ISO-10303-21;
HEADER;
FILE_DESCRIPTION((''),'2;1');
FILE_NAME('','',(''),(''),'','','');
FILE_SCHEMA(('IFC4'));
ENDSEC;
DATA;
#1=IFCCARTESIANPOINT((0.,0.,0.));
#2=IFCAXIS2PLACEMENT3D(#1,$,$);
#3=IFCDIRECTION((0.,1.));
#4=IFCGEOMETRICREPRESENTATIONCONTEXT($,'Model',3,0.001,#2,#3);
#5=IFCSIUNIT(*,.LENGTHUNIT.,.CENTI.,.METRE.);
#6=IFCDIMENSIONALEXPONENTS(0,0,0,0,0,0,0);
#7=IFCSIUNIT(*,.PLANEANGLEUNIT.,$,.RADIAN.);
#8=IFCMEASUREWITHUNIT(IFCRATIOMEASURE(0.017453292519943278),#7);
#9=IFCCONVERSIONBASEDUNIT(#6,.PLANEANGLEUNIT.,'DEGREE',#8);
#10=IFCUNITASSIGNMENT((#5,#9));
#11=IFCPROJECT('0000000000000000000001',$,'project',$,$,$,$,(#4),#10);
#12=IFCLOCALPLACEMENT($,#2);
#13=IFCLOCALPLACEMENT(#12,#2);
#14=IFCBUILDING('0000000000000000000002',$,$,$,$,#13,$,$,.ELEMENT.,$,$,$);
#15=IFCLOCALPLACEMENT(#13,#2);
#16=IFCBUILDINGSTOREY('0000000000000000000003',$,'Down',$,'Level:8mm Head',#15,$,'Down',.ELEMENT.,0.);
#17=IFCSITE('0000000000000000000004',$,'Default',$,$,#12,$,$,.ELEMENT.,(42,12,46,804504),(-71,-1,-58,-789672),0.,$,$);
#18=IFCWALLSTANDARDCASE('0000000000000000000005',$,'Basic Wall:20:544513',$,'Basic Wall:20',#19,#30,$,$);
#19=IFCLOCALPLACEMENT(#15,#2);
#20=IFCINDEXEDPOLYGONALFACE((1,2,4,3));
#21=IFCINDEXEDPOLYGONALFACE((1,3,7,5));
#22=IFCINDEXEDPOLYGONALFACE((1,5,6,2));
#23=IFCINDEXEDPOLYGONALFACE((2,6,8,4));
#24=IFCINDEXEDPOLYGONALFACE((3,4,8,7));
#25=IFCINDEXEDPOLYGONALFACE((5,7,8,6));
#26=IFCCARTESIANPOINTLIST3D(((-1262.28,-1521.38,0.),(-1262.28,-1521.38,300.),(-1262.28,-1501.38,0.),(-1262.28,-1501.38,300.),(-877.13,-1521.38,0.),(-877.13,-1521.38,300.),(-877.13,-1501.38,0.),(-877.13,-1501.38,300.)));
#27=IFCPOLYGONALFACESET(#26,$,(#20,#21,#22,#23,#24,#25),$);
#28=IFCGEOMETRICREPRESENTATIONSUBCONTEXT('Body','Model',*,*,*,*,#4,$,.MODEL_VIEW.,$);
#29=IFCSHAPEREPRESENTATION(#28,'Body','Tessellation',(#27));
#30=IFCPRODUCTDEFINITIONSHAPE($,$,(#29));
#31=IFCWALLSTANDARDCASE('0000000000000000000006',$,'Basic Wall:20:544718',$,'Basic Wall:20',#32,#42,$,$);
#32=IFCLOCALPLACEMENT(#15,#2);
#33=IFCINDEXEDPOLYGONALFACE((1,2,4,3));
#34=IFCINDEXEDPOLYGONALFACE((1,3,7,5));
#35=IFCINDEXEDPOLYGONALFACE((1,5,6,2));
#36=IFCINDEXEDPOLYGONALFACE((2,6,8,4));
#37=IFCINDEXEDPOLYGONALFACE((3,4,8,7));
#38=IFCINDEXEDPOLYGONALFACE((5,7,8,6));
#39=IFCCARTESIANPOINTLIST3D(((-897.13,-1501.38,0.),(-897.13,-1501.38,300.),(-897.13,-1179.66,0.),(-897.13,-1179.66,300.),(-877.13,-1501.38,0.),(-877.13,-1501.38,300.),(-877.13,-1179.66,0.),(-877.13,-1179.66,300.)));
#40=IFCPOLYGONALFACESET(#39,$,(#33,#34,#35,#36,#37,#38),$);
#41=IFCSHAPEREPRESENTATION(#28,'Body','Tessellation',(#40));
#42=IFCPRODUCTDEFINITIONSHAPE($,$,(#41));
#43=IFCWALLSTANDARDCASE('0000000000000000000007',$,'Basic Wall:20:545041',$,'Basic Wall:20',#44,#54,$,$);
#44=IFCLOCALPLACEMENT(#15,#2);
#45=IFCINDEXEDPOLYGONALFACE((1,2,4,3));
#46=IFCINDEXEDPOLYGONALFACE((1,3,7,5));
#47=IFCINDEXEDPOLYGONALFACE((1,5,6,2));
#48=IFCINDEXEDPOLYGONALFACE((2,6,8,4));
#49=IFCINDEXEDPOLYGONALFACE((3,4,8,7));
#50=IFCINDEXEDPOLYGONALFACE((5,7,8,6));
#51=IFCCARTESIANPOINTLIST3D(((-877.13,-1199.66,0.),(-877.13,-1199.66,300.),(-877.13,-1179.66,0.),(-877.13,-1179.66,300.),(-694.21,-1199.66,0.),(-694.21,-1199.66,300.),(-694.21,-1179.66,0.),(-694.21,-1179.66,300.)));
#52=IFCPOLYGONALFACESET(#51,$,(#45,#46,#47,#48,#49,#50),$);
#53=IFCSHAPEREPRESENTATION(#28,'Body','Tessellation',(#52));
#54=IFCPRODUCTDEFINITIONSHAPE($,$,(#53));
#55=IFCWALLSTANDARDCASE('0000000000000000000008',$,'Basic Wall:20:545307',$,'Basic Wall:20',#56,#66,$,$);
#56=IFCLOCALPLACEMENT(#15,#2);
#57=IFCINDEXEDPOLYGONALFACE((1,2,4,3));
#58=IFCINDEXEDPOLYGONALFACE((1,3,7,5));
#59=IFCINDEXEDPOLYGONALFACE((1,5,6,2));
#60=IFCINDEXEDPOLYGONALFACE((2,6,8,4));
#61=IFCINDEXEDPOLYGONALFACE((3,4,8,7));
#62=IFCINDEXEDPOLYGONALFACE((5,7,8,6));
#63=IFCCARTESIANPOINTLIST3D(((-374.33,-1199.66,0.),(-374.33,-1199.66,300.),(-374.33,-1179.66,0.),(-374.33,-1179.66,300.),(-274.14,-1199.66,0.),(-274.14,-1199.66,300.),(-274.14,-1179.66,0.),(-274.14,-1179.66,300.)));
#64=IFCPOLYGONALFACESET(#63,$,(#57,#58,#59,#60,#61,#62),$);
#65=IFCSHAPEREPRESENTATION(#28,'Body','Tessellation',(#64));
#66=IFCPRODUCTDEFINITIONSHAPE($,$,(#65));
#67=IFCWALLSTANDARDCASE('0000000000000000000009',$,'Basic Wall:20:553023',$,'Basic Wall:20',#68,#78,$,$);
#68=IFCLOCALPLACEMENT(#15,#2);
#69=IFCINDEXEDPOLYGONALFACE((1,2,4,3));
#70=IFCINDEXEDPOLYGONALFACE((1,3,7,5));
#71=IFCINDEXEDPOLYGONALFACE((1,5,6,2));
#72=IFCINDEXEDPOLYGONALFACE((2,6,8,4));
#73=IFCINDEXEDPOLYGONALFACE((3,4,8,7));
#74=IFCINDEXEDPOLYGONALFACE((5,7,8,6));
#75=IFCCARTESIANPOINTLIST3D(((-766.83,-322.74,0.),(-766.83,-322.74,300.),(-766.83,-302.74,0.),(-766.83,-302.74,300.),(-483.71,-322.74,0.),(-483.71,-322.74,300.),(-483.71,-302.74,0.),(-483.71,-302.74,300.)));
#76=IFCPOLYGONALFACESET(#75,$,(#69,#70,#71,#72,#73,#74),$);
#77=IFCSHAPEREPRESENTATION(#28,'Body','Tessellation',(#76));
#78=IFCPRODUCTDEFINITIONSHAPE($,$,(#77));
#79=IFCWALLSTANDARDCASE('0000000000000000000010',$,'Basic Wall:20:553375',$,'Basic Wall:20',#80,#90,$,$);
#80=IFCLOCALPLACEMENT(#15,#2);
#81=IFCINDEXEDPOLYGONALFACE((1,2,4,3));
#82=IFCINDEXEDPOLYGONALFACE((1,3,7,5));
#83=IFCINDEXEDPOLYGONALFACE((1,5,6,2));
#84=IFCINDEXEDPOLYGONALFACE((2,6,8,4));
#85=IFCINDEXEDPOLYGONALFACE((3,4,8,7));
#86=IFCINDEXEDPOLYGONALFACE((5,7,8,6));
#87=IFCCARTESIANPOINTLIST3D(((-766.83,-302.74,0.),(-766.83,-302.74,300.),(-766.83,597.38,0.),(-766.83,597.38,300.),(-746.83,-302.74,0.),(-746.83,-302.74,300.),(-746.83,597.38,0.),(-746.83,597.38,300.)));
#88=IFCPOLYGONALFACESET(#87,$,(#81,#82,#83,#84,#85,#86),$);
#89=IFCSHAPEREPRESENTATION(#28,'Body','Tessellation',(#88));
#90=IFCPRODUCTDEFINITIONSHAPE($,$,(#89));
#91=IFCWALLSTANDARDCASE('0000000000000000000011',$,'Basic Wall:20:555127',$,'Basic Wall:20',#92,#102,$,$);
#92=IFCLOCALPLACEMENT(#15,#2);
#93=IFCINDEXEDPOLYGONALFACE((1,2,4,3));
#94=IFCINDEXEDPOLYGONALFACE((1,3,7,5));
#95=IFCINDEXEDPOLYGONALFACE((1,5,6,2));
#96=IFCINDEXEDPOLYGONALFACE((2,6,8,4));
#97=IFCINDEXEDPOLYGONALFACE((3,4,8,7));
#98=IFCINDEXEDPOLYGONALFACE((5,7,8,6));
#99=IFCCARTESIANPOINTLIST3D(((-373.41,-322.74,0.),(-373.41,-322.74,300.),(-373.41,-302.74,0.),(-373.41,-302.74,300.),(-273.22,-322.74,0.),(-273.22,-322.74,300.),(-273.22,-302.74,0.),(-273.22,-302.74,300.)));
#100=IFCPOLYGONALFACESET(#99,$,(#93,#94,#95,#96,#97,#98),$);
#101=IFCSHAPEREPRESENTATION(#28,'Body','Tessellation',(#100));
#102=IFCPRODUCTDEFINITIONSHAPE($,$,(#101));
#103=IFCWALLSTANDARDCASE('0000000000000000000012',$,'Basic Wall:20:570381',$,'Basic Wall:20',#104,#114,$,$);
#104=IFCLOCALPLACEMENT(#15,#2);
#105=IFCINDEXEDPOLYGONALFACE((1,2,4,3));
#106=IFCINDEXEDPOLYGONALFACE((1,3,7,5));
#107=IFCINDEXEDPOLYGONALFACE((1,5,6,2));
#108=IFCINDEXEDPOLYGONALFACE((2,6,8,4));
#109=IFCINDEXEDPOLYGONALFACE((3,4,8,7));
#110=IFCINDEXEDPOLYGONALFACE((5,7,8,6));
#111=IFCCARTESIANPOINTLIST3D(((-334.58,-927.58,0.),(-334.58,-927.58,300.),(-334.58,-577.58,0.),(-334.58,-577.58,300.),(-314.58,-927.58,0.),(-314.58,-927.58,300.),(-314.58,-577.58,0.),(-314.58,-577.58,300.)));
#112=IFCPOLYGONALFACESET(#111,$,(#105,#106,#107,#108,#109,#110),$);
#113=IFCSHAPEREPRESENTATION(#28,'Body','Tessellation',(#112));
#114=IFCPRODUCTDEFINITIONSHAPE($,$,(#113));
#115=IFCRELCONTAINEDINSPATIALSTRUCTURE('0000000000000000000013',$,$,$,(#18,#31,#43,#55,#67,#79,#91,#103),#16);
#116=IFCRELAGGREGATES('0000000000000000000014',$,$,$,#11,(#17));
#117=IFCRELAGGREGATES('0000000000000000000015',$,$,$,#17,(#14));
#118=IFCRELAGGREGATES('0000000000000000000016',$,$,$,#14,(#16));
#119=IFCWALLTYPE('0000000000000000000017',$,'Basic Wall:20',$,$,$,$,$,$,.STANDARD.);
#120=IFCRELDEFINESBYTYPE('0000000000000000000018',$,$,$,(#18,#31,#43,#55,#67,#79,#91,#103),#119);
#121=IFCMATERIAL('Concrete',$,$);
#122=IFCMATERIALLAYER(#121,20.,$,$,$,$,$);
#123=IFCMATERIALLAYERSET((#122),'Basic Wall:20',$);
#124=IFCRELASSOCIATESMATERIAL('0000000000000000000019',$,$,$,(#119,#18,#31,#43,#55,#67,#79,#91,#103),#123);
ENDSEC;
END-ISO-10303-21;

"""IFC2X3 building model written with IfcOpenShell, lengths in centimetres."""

from ifc_helpers import new_model, entity, si_unit, converted_unit, direction, frame, frame_2d, origin, place, context, subcontext, project, spatial, rectangle, extrude, material, layer, layer_set, layer_usage, type_object, element, save


model = new_model("IFC2X3")

# Units and contexts
model_context = context("Model", 3, precision=0.001, world=origin(), true_north=direction((0.0, 1.0)))
body_context = subcontext(model_context, "Body", "Model", "MODEL_VIEW")
ifc_project = project(units=[si_unit("LENGTHUNIT", "METRE", prefix="CENTI"), converted_unit("PLANEANGLEUNIT", "DEGREE", entity("IfcRatioMeasure", 0.017453292519943278), si_unit("PLANEANGLEUNIT", "RADIAN"), dimensions=[0, 0, 0, 0, 0, 0, 0])], contexts=[model_context])

# Site, building, storey
site_placement = place(None, origin())
site = spatial("IfcSite", under=ifc_project, at=site_placement, Name="Default", CompositionType="ELEMENT", RefLatitude=(42, 12, 46, 804504), RefLongitude=(-71, -1, -58, -789672), RefElevation=0.0)
building_placement = place(site_placement, origin())
building = spatial("IfcBuilding", under=site, at=building_placement, CompositionType="ELEMENT")
storey_placement = place(building_placement, origin())
storey = spatial("IfcBuildingStorey", under=building, at=storey_placement, Name="Down", ObjectType="Level:8mm Head", LongName="Down", CompositionType="ELEMENT", Elevation=0.0)

# Walls
ifc_material = material(Name="Concrete")
ifc_layer_1 = layer(ifc_material, 20.0)
ifc_layer_set_1 = layer_set([ifc_layer_1], Name="Basic Wall:20")
wall_type_1 = type_object("IfcWallType", Name="Basic Wall:20", PredefinedType="STANDARD", material=ifc_layer_set_1)
ifc_layer_usage_1 = layer_usage(ifc_layer_set_1, "AXIS2", "POSITIVE", -10.0)
wall_1_placement = place(storey_placement, frame((-1262.28, -1511.38, 0.0)))
element("IfcWallStandardCase", 1, at=wall_1_placement, inside=storey, type_object=wall_type_1, material=ifc_layer_usage_1, Name="Basic Wall:20:544513", ObjectType="Basic Wall:20", context=body_context, shape_type="SweptSolid", body=[
    extrude(rectangle(XDim=385.15, YDim=20.0, at=frame_2d((192.57, 0.0), x_axis=(-1.0, 0.0))), origin(), (0.0, 0.0, 1.0), 300.0),
])
ifc_layer_usage_2 = layer_usage(ifc_layer_set_1, "AXIS2", "POSITIVE", -10.0)
wall_2_placement = place(storey_placement, frame((-887.13, -1501.38, 0.0), z_axis=(0.0, 0.0, 1.0), x_axis=(0.0, 1.0, 0.0)))
element("IfcWallStandardCase", 2, at=wall_2_placement, inside=storey, type_object=wall_type_1, material=ifc_layer_usage_2, Name="Basic Wall:20:544718", ObjectType="Basic Wall:20", context=body_context, shape_type="SweptSolid", body=[
    extrude(rectangle(XDim=321.72, YDim=20.0, at=frame_2d((160.86, 0.0), x_axis=(-1.0, 0.0))), origin(), (0.0, 0.0, 1.0), 300.0),
])
ifc_layer_usage_3 = layer_usage(ifc_layer_set_1, "AXIS2", "NEGATIVE", 10.0)
wall_3_placement = place(storey_placement, frame((-877.13, -1189.66, 0.0)))
element("IfcWallStandardCase", 3, at=wall_3_placement, inside=storey, type_object=wall_type_1, material=ifc_layer_usage_3, Name="Basic Wall:20:545041", ObjectType="Basic Wall:20", context=body_context, shape_type="SweptSolid", body=[
    extrude(rectangle(XDim=182.92, YDim=20.0, at=frame_2d((91.46, 0.0), x_axis=(-1.0, 0.0))), origin(), (0.0, 0.0, 1.0), 300.0),
])
ifc_layer_usage_4 = layer_usage(ifc_layer_set_1, "AXIS2", "POSITIVE", -10.0)
wall_4_placement = place(storey_placement, frame((-374.33, -1189.66, 0.0)))
element("IfcWallStandardCase", 4, at=wall_4_placement, inside=storey, type_object=wall_type_1, material=ifc_layer_usage_4, Name="Basic Wall:20:545307", ObjectType="Basic Wall:20", context=body_context, shape_type="SweptSolid", body=[
    extrude(rectangle(XDim=100.19, YDim=20.0, at=frame_2d((50.1, 0.0), x_axis=(-1.0, 0.0))), origin(), (0.0, 0.0, 1.0), 300.0),
])
ifc_layer_usage_5 = layer_usage(ifc_layer_set_1, "AXIS2", "POSITIVE", -10.0)
wall_5_placement = place(storey_placement, frame((-766.83, -312.74, 0.0)))
element("IfcWallStandardCase", 5, at=wall_5_placement, inside=storey, type_object=wall_type_1, material=ifc_layer_usage_5, Name="Basic Wall:20:553023", ObjectType="Basic Wall:20", context=body_context, shape_type="SweptSolid", body=[
    extrude(rectangle(XDim=283.11, YDim=20.0, at=frame_2d((141.56, 0.0), x_axis=(-1.0, 0.0))), origin(), (0.0, 0.0, 1.0), 300.0),
])
ifc_layer_usage_6 = layer_usage(ifc_layer_set_1, "AXIS2", "NEGATIVE", 10.0)
wall_6_placement = place(storey_placement, frame((-756.83, -302.74, 0.0), z_axis=(0.0, 0.0, 1.0), x_axis=(0.0, 1.0, 0.0)))
element("IfcWallStandardCase", 6, at=wall_6_placement, inside=storey, type_object=wall_type_1, material=ifc_layer_usage_6, Name="Basic Wall:20:553375", ObjectType="Basic Wall:20", context=body_context, shape_type="SweptSolid", body=[
    extrude(rectangle(XDim=900.12, YDim=20.0, at=frame_2d((450.06, 0.0), x_axis=(-1.0, 0.0))), origin(), (0.0, 0.0, 1.0), 300.0),
])
ifc_layer_usage_7 = layer_usage(ifc_layer_set_1, "AXIS2", "NEGATIVE", 10.0)
wall_7_placement = place(storey_placement, frame((-273.22, -312.74, 0.0), z_axis=(0.0, 0.0, 1.0), x_axis=(-1.0, 0.0, 0.0)))
element("IfcWallStandardCase", 7, at=wall_7_placement, inside=storey, type_object=wall_type_1, material=ifc_layer_usage_7, Name="Basic Wall:20:555127", ObjectType="Basic Wall:20", context=body_context, shape_type="SweptSolid", body=[
    extrude(rectangle(XDim=100.19, YDim=20.0, at=frame_2d((50.1, 0.0), x_axis=(-1.0, 0.0))), origin(), (0.0, 0.0, 1.0), 300.0),
])
ifc_layer_usage_8 = layer_usage(ifc_layer_set_1, "AXIS2", "POSITIVE", -10.0)
wall_8_placement = place(storey_placement, frame((-324.58, -927.58, 0.0), z_axis=(0.0, 0.0, 1.0), x_axis=(0.0, 1.0, 0.0)))
element("IfcWallStandardCase", 8, at=wall_8_placement, inside=storey, type_object=wall_type_1, material=ifc_layer_usage_8, Name="Basic Wall:20:570381", ObjectType="Basic Wall:20", context=body_context, shape_type="SweptSolid", body=[
    extrude(rectangle(XDim=350.0, YDim=20.0, at=frame_2d((175.0, 0.0), x_axis=(-1.0, 0.0))), origin(), (0.0, 0.0, 1.0), 300.0),
])

save(model, "model.ifc")
